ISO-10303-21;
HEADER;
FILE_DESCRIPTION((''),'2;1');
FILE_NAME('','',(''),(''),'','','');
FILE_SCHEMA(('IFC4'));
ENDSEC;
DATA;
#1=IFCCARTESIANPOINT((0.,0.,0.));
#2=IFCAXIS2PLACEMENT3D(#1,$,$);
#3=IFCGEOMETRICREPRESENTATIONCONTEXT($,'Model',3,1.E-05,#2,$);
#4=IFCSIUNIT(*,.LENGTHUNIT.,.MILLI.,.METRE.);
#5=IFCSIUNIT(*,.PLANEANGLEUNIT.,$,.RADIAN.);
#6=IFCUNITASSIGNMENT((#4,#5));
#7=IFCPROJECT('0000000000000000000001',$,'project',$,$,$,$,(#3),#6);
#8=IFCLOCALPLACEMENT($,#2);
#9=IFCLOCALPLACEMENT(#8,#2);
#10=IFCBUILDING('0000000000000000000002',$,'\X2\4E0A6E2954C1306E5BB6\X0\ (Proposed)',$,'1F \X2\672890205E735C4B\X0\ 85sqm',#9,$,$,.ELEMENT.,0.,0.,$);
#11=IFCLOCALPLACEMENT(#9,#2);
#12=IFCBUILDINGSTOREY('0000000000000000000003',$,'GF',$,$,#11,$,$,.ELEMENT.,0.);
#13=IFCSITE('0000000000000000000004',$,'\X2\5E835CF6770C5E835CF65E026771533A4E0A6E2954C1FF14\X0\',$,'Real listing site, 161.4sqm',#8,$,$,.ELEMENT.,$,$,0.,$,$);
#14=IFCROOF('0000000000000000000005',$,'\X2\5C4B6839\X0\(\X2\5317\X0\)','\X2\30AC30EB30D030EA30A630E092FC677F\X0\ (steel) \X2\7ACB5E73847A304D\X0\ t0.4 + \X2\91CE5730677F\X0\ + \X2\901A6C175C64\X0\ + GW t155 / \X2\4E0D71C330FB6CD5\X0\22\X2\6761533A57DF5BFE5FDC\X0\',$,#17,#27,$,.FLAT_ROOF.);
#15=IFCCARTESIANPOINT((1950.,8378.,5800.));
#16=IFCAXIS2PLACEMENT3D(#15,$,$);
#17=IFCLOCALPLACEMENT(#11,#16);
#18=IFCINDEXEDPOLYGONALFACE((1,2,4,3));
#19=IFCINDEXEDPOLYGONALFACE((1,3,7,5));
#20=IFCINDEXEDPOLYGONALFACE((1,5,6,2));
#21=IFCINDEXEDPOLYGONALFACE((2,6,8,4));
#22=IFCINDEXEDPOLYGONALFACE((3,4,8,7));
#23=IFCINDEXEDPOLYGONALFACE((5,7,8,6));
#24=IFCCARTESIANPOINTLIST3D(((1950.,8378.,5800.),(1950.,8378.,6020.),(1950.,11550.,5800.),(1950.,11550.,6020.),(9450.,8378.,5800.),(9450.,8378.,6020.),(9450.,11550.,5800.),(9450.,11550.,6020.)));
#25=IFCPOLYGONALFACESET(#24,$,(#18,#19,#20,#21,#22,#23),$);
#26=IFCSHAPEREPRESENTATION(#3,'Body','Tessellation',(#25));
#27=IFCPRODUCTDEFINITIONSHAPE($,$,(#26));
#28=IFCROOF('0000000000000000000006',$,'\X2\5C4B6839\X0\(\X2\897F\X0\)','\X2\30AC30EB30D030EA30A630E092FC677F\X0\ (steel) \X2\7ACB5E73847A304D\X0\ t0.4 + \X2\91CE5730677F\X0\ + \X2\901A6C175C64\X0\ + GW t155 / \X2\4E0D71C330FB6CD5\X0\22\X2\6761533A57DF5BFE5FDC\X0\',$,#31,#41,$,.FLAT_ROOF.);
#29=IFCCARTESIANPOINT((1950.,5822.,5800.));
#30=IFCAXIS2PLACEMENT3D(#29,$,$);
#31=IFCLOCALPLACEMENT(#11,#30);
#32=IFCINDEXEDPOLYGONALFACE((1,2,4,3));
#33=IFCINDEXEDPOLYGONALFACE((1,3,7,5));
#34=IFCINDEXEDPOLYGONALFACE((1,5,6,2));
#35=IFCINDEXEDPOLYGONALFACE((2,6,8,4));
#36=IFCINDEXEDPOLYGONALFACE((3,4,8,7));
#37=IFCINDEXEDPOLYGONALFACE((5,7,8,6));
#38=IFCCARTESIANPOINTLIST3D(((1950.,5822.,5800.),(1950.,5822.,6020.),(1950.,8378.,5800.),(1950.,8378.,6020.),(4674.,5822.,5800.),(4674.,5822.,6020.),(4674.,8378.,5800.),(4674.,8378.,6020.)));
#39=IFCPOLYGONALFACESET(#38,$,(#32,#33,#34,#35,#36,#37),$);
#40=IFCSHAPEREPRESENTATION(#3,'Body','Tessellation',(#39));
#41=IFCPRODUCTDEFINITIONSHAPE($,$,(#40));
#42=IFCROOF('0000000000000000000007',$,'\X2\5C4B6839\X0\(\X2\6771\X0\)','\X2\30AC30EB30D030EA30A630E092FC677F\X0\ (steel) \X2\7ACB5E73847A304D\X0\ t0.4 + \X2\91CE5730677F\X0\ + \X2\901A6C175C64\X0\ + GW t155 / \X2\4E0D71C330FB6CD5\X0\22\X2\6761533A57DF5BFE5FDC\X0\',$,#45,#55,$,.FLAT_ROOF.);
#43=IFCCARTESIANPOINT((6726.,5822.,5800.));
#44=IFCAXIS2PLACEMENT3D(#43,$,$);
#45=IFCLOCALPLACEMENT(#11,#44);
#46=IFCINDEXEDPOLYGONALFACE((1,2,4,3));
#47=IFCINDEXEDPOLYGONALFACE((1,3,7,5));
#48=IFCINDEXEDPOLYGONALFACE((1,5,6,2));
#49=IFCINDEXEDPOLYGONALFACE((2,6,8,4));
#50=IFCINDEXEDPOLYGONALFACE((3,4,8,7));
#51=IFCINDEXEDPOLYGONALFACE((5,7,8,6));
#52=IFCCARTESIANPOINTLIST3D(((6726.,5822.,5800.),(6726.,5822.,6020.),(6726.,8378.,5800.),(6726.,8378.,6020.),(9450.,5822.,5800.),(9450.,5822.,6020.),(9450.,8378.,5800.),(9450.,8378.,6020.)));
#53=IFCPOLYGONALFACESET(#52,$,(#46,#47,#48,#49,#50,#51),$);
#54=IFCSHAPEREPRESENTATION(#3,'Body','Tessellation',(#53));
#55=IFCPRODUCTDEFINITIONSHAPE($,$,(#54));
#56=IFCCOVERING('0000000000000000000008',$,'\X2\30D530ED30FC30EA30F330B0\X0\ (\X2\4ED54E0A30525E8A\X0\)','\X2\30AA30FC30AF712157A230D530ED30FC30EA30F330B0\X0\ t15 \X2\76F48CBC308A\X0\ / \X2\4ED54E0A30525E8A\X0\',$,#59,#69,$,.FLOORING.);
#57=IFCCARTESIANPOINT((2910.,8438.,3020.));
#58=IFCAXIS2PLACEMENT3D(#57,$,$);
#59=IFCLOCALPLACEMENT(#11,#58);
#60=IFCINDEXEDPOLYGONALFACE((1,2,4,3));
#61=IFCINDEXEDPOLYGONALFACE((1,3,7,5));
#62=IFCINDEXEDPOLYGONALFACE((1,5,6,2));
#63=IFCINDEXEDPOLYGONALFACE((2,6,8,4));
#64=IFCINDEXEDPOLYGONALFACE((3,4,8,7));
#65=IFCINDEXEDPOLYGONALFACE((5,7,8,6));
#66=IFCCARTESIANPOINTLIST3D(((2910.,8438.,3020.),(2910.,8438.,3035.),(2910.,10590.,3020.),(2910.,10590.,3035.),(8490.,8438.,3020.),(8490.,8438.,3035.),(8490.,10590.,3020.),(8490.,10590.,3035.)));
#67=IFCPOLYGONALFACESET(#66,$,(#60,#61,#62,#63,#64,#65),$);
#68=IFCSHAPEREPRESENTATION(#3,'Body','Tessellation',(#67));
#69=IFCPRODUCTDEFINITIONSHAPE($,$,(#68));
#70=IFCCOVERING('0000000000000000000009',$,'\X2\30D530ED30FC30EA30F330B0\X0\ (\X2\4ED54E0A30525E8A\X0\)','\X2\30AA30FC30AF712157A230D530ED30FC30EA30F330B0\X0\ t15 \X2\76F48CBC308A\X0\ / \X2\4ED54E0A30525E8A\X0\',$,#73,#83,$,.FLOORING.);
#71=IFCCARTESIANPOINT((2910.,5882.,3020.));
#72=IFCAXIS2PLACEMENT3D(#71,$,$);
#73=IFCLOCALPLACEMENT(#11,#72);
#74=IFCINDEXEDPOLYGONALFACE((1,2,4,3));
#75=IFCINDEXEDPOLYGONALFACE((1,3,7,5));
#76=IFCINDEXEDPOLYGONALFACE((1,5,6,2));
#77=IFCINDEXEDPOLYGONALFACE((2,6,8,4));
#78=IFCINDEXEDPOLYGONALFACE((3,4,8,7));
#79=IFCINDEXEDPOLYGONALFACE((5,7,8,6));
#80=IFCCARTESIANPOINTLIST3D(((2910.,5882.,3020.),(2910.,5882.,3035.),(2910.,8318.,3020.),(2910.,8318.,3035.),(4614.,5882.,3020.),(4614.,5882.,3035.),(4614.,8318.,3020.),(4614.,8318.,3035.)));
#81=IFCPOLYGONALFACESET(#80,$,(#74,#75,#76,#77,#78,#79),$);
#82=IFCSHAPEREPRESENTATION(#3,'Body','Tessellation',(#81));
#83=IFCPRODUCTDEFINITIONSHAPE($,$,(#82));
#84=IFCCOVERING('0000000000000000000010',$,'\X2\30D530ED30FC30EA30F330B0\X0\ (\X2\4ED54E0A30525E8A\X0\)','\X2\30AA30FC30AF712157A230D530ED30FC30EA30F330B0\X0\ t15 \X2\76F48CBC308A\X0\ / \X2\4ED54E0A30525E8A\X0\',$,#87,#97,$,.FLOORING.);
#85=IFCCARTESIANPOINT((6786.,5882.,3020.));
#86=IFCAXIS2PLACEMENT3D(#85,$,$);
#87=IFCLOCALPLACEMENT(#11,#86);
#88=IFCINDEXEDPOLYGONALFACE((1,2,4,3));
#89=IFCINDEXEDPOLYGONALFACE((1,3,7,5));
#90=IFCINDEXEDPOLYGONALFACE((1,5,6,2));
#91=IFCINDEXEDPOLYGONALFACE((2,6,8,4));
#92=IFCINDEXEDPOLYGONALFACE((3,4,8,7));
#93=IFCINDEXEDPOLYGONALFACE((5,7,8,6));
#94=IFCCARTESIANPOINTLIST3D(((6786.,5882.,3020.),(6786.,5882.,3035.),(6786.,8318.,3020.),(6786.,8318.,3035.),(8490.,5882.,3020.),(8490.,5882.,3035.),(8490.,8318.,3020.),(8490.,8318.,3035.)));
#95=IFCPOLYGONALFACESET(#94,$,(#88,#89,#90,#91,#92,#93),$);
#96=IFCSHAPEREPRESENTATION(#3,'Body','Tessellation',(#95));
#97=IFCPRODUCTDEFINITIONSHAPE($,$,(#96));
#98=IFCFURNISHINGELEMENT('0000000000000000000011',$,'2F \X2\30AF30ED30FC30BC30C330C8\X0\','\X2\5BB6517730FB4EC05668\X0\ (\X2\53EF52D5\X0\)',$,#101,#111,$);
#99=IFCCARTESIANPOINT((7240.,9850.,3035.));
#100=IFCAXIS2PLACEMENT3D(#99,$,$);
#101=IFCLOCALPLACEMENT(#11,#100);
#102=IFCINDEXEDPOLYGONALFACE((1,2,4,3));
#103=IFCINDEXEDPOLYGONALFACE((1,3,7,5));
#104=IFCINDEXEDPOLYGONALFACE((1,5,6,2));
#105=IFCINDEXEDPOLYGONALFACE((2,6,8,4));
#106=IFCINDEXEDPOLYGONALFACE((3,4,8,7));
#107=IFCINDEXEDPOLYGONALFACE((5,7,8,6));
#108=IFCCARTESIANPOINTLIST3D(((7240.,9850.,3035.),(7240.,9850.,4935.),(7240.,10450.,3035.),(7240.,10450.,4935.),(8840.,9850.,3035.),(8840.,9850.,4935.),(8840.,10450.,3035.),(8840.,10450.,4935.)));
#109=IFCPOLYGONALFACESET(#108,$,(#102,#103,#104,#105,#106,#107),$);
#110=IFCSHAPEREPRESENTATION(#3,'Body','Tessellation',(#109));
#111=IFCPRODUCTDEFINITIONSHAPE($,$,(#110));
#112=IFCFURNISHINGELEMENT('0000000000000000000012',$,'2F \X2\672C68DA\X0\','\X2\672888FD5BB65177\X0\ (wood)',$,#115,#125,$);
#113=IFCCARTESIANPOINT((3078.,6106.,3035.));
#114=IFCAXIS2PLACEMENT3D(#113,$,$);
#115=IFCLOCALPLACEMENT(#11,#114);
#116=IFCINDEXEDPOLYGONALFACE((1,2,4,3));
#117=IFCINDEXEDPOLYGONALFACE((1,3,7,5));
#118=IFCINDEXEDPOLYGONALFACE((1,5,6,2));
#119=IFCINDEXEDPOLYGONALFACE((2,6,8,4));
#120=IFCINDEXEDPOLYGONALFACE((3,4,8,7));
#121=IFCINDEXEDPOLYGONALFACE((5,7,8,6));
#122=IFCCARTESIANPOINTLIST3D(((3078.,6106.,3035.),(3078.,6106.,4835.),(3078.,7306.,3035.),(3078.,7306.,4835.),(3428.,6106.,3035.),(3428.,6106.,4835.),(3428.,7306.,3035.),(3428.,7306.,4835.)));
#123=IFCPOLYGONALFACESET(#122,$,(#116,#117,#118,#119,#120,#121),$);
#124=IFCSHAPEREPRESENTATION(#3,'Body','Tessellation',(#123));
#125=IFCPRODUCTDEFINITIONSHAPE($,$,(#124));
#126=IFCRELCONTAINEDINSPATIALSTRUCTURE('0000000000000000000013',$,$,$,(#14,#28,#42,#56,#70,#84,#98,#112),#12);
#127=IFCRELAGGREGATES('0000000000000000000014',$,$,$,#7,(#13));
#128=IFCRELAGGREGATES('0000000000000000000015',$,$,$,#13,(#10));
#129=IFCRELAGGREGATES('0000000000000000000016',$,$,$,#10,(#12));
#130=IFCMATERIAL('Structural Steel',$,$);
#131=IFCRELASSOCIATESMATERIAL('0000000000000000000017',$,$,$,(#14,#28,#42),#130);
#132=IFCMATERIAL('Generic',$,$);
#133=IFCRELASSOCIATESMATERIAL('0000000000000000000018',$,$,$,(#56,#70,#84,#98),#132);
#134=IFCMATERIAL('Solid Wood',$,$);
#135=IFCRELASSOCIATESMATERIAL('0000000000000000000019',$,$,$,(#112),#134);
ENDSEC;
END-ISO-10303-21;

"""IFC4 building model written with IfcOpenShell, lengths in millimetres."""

from ifc_helpers import new_model, si_unit, frame, frame_2d, origin, place, context, project, spatial, rectangle, extrude, material, element, save


model = new_model("IFC4")

# Units and contexts
model_context = context("Model", 3, precision=1e-05, world=origin())
ifc_project = project(units=[si_unit("LENGTHUNIT", "METRE", prefix="MILLI"), si_unit("PLANEANGLEUNIT", "RADIAN")], contexts=[model_context])

# Site, building, storey
site_placement = place(None, origin())
site = spatial("IfcSite", under=ifc_project, at=site_placement, Name="広島県広島市東区上温品４", ObjectType="Real listing site, 161.4sqm", CompositionType="ELEMENT", RefElevation=0.0)
building_placement = place(site_placement, origin())
building = spatial("IfcBuilding", under=site, at=building_placement, Name="上温品の家 (Proposed)", ObjectType="1F 木造平屋 85sqm", CompositionType="ELEMENT", ElevationOfRefHeight=0.0, ElevationOfTerrain=0.0)
storey_placement = place(building_placement, origin())
storey = spatial("IfcBuildingStorey", under=building, at=storey_placement, Name="GF", CompositionType="ELEMENT", Elevation=0.0)

# Shared definitions
ifc_material_1 = material(Name="Solid Wood")

# Shared definitions
ifc_material_2 = material(Name="Generic")

# Roofs
ifc_material_3 = material(Name="Structural Steel")
for number, where, name in (
    (1, (1950.0, 8378.0, 5800.0), "屋根(北)"),
):
    element("IfcRoof", number, at=place(storey_placement, frame(where)), inside=storey, material=ifc_material_3, Name=name, Description="ガルバリウム鋼板 (steel) 立平葺き t0.4 + 野地板 + 通気層 + GW t155 / 不燃・法22条区域対応", PredefinedType="FLAT_ROOF", context=model_context, shape_type="SweptSolid", body=[
        extrude(rectangle(XDim=7500.0, YDim=3172.0, at=frame_2d((3750.0, 1586.0))), frame((1950.0, 8378.0, 5800.0)), (0.0, 0.0, 1.0), 220.0),
    ])
roof_1_placement = place(storey_placement, frame((1950.0, 5822.0, 5800.0)))
element("IfcRoof", 2, at=roof_1_placement, inside=storey, material=ifc_material_3, Name="屋根(西)", Description="ガルバリウム鋼板 (steel) 立平葺き t0.4 + 野地板 + 通気層 + GW t155 / 不燃・法22条区域対応", PredefinedType="FLAT_ROOF", context=model_context, shape_type="SweptSolid", body=[
    extrude(rectangle(XDim=2724.0, YDim=2556.0, at=frame_2d((1362.0, 1278.0))), frame((1950.0, 5822.0, 5800.0)), (0.0, 0.0, 1.0), 220.0),
])
roof_2_placement = place(storey_placement, frame((6726.0, 5822.0, 5800.0)))
element("IfcRoof", 3, at=roof_2_placement, inside=storey, material=ifc_material_3, Name="屋根(東)", Description="ガルバリウム鋼板 (steel) 立平葺き t0.4 + 野地板 + 通気層 + GW t155 / 不燃・法22条区域対応", PredefinedType="FLAT_ROOF", context=model_context, shape_type="SweptSolid", body=[
    extrude(rectangle(XDim=2724.0, YDim=2556.0, at=frame_2d((1362.0, 1278.0))), frame((6726.0, 5822.0, 5800.0)), (0.0, 0.0, 1.0), 220.0),
])

# Coverings
covering_1_placement = place(storey_placement, frame((2910.0, 8438.0, 3020.0)))
element("IfcCovering", 4, at=covering_1_placement, inside=storey, material=ifc_material_2, Name="フローリング (仕上げ床)", Description="オーク無垢フローリング t15 直貼り / 仕上げ床", PredefinedType="FLOORING", context=model_context, shape_type="SweptSolid", body=[
    extrude(rectangle(XDim=5580.0, YDim=2152.0, at=frame_2d((2790.0, 1076.0))), frame((2910.0, 8438.0, 3020.0)), (0.0, 0.0, 1.0), 15.0),
])
covering_2_placement = place(storey_placement, frame((2910.0, 5882.0, 3020.0)))
element("IfcCovering", 5, at=covering_2_placement, inside=storey, material=ifc_material_2, Name="フローリング (仕上げ床)", Description="オーク無垢フローリング t15 直貼り / 仕上げ床", PredefinedType="FLOORING", context=model_context, shape_type="SweptSolid", body=[
    extrude(rectangle(XDim=1704.0, YDim=2436.0, at=frame_2d((852.0, 1218.0))), frame((2910.0, 5882.0, 3020.0)), (0.0, 0.0, 1.0), 15.0),
])
covering_3_placement = place(storey_placement, frame((6786.0, 5882.0, 3020.0)))
element("IfcCovering", 6, at=covering_3_placement, inside=storey, material=ifc_material_2, Name="フローリング (仕上げ床)", Description="オーク無垢フローリング t15 直貼り / 仕上げ床", PredefinedType="FLOORING", context=model_context, shape_type="SweptSolid", body=[
    extrude(rectangle(XDim=1704.0, YDim=2436.0, at=frame_2d((852.0, 1218.0))), frame((6786.0, 5882.0, 3020.0)), (0.0, 0.0, 1.0), 15.0),
])

# Furnishing elements
furnishing_1_placement = place(storey_placement, frame((7240.0, 9850.0, 3035.0)))
element("IfcFurnishingElement", 7, at=furnishing_1_placement, inside=storey, material=ifc_material_2, Name="2F クローゼット", Description="家具・什器 (可動)", context=model_context, shape_type="SweptSolid", body=[
    extrude(rectangle(XDim=1600.0, YDim=600.0, at=frame_2d((800.0, 300.0))), frame((7240.0, 9850.0, 3035.0)), (0.0, 0.0, 1.0), 1900.0),
])
furnishing_2_placement = place(storey_placement, frame((3078.0, 6106.0, 3035.0)))
element("IfcFurnishingElement", 8, at=furnishing_2_placement, inside=storey, material=ifc_material_1, Name="2F 本棚", Description="木製家具 (wood)", context=model_context, shape_type="SweptSolid", body=[
    extrude(rectangle(XDim=350.0, YDim=1200.0, at=frame_2d((175.0, 600.0))), frame((3078.0, 6106.0, 3035.0)), (0.0, 0.0, 1.0), 1800.0),
])

save(model, "model.ifc")
